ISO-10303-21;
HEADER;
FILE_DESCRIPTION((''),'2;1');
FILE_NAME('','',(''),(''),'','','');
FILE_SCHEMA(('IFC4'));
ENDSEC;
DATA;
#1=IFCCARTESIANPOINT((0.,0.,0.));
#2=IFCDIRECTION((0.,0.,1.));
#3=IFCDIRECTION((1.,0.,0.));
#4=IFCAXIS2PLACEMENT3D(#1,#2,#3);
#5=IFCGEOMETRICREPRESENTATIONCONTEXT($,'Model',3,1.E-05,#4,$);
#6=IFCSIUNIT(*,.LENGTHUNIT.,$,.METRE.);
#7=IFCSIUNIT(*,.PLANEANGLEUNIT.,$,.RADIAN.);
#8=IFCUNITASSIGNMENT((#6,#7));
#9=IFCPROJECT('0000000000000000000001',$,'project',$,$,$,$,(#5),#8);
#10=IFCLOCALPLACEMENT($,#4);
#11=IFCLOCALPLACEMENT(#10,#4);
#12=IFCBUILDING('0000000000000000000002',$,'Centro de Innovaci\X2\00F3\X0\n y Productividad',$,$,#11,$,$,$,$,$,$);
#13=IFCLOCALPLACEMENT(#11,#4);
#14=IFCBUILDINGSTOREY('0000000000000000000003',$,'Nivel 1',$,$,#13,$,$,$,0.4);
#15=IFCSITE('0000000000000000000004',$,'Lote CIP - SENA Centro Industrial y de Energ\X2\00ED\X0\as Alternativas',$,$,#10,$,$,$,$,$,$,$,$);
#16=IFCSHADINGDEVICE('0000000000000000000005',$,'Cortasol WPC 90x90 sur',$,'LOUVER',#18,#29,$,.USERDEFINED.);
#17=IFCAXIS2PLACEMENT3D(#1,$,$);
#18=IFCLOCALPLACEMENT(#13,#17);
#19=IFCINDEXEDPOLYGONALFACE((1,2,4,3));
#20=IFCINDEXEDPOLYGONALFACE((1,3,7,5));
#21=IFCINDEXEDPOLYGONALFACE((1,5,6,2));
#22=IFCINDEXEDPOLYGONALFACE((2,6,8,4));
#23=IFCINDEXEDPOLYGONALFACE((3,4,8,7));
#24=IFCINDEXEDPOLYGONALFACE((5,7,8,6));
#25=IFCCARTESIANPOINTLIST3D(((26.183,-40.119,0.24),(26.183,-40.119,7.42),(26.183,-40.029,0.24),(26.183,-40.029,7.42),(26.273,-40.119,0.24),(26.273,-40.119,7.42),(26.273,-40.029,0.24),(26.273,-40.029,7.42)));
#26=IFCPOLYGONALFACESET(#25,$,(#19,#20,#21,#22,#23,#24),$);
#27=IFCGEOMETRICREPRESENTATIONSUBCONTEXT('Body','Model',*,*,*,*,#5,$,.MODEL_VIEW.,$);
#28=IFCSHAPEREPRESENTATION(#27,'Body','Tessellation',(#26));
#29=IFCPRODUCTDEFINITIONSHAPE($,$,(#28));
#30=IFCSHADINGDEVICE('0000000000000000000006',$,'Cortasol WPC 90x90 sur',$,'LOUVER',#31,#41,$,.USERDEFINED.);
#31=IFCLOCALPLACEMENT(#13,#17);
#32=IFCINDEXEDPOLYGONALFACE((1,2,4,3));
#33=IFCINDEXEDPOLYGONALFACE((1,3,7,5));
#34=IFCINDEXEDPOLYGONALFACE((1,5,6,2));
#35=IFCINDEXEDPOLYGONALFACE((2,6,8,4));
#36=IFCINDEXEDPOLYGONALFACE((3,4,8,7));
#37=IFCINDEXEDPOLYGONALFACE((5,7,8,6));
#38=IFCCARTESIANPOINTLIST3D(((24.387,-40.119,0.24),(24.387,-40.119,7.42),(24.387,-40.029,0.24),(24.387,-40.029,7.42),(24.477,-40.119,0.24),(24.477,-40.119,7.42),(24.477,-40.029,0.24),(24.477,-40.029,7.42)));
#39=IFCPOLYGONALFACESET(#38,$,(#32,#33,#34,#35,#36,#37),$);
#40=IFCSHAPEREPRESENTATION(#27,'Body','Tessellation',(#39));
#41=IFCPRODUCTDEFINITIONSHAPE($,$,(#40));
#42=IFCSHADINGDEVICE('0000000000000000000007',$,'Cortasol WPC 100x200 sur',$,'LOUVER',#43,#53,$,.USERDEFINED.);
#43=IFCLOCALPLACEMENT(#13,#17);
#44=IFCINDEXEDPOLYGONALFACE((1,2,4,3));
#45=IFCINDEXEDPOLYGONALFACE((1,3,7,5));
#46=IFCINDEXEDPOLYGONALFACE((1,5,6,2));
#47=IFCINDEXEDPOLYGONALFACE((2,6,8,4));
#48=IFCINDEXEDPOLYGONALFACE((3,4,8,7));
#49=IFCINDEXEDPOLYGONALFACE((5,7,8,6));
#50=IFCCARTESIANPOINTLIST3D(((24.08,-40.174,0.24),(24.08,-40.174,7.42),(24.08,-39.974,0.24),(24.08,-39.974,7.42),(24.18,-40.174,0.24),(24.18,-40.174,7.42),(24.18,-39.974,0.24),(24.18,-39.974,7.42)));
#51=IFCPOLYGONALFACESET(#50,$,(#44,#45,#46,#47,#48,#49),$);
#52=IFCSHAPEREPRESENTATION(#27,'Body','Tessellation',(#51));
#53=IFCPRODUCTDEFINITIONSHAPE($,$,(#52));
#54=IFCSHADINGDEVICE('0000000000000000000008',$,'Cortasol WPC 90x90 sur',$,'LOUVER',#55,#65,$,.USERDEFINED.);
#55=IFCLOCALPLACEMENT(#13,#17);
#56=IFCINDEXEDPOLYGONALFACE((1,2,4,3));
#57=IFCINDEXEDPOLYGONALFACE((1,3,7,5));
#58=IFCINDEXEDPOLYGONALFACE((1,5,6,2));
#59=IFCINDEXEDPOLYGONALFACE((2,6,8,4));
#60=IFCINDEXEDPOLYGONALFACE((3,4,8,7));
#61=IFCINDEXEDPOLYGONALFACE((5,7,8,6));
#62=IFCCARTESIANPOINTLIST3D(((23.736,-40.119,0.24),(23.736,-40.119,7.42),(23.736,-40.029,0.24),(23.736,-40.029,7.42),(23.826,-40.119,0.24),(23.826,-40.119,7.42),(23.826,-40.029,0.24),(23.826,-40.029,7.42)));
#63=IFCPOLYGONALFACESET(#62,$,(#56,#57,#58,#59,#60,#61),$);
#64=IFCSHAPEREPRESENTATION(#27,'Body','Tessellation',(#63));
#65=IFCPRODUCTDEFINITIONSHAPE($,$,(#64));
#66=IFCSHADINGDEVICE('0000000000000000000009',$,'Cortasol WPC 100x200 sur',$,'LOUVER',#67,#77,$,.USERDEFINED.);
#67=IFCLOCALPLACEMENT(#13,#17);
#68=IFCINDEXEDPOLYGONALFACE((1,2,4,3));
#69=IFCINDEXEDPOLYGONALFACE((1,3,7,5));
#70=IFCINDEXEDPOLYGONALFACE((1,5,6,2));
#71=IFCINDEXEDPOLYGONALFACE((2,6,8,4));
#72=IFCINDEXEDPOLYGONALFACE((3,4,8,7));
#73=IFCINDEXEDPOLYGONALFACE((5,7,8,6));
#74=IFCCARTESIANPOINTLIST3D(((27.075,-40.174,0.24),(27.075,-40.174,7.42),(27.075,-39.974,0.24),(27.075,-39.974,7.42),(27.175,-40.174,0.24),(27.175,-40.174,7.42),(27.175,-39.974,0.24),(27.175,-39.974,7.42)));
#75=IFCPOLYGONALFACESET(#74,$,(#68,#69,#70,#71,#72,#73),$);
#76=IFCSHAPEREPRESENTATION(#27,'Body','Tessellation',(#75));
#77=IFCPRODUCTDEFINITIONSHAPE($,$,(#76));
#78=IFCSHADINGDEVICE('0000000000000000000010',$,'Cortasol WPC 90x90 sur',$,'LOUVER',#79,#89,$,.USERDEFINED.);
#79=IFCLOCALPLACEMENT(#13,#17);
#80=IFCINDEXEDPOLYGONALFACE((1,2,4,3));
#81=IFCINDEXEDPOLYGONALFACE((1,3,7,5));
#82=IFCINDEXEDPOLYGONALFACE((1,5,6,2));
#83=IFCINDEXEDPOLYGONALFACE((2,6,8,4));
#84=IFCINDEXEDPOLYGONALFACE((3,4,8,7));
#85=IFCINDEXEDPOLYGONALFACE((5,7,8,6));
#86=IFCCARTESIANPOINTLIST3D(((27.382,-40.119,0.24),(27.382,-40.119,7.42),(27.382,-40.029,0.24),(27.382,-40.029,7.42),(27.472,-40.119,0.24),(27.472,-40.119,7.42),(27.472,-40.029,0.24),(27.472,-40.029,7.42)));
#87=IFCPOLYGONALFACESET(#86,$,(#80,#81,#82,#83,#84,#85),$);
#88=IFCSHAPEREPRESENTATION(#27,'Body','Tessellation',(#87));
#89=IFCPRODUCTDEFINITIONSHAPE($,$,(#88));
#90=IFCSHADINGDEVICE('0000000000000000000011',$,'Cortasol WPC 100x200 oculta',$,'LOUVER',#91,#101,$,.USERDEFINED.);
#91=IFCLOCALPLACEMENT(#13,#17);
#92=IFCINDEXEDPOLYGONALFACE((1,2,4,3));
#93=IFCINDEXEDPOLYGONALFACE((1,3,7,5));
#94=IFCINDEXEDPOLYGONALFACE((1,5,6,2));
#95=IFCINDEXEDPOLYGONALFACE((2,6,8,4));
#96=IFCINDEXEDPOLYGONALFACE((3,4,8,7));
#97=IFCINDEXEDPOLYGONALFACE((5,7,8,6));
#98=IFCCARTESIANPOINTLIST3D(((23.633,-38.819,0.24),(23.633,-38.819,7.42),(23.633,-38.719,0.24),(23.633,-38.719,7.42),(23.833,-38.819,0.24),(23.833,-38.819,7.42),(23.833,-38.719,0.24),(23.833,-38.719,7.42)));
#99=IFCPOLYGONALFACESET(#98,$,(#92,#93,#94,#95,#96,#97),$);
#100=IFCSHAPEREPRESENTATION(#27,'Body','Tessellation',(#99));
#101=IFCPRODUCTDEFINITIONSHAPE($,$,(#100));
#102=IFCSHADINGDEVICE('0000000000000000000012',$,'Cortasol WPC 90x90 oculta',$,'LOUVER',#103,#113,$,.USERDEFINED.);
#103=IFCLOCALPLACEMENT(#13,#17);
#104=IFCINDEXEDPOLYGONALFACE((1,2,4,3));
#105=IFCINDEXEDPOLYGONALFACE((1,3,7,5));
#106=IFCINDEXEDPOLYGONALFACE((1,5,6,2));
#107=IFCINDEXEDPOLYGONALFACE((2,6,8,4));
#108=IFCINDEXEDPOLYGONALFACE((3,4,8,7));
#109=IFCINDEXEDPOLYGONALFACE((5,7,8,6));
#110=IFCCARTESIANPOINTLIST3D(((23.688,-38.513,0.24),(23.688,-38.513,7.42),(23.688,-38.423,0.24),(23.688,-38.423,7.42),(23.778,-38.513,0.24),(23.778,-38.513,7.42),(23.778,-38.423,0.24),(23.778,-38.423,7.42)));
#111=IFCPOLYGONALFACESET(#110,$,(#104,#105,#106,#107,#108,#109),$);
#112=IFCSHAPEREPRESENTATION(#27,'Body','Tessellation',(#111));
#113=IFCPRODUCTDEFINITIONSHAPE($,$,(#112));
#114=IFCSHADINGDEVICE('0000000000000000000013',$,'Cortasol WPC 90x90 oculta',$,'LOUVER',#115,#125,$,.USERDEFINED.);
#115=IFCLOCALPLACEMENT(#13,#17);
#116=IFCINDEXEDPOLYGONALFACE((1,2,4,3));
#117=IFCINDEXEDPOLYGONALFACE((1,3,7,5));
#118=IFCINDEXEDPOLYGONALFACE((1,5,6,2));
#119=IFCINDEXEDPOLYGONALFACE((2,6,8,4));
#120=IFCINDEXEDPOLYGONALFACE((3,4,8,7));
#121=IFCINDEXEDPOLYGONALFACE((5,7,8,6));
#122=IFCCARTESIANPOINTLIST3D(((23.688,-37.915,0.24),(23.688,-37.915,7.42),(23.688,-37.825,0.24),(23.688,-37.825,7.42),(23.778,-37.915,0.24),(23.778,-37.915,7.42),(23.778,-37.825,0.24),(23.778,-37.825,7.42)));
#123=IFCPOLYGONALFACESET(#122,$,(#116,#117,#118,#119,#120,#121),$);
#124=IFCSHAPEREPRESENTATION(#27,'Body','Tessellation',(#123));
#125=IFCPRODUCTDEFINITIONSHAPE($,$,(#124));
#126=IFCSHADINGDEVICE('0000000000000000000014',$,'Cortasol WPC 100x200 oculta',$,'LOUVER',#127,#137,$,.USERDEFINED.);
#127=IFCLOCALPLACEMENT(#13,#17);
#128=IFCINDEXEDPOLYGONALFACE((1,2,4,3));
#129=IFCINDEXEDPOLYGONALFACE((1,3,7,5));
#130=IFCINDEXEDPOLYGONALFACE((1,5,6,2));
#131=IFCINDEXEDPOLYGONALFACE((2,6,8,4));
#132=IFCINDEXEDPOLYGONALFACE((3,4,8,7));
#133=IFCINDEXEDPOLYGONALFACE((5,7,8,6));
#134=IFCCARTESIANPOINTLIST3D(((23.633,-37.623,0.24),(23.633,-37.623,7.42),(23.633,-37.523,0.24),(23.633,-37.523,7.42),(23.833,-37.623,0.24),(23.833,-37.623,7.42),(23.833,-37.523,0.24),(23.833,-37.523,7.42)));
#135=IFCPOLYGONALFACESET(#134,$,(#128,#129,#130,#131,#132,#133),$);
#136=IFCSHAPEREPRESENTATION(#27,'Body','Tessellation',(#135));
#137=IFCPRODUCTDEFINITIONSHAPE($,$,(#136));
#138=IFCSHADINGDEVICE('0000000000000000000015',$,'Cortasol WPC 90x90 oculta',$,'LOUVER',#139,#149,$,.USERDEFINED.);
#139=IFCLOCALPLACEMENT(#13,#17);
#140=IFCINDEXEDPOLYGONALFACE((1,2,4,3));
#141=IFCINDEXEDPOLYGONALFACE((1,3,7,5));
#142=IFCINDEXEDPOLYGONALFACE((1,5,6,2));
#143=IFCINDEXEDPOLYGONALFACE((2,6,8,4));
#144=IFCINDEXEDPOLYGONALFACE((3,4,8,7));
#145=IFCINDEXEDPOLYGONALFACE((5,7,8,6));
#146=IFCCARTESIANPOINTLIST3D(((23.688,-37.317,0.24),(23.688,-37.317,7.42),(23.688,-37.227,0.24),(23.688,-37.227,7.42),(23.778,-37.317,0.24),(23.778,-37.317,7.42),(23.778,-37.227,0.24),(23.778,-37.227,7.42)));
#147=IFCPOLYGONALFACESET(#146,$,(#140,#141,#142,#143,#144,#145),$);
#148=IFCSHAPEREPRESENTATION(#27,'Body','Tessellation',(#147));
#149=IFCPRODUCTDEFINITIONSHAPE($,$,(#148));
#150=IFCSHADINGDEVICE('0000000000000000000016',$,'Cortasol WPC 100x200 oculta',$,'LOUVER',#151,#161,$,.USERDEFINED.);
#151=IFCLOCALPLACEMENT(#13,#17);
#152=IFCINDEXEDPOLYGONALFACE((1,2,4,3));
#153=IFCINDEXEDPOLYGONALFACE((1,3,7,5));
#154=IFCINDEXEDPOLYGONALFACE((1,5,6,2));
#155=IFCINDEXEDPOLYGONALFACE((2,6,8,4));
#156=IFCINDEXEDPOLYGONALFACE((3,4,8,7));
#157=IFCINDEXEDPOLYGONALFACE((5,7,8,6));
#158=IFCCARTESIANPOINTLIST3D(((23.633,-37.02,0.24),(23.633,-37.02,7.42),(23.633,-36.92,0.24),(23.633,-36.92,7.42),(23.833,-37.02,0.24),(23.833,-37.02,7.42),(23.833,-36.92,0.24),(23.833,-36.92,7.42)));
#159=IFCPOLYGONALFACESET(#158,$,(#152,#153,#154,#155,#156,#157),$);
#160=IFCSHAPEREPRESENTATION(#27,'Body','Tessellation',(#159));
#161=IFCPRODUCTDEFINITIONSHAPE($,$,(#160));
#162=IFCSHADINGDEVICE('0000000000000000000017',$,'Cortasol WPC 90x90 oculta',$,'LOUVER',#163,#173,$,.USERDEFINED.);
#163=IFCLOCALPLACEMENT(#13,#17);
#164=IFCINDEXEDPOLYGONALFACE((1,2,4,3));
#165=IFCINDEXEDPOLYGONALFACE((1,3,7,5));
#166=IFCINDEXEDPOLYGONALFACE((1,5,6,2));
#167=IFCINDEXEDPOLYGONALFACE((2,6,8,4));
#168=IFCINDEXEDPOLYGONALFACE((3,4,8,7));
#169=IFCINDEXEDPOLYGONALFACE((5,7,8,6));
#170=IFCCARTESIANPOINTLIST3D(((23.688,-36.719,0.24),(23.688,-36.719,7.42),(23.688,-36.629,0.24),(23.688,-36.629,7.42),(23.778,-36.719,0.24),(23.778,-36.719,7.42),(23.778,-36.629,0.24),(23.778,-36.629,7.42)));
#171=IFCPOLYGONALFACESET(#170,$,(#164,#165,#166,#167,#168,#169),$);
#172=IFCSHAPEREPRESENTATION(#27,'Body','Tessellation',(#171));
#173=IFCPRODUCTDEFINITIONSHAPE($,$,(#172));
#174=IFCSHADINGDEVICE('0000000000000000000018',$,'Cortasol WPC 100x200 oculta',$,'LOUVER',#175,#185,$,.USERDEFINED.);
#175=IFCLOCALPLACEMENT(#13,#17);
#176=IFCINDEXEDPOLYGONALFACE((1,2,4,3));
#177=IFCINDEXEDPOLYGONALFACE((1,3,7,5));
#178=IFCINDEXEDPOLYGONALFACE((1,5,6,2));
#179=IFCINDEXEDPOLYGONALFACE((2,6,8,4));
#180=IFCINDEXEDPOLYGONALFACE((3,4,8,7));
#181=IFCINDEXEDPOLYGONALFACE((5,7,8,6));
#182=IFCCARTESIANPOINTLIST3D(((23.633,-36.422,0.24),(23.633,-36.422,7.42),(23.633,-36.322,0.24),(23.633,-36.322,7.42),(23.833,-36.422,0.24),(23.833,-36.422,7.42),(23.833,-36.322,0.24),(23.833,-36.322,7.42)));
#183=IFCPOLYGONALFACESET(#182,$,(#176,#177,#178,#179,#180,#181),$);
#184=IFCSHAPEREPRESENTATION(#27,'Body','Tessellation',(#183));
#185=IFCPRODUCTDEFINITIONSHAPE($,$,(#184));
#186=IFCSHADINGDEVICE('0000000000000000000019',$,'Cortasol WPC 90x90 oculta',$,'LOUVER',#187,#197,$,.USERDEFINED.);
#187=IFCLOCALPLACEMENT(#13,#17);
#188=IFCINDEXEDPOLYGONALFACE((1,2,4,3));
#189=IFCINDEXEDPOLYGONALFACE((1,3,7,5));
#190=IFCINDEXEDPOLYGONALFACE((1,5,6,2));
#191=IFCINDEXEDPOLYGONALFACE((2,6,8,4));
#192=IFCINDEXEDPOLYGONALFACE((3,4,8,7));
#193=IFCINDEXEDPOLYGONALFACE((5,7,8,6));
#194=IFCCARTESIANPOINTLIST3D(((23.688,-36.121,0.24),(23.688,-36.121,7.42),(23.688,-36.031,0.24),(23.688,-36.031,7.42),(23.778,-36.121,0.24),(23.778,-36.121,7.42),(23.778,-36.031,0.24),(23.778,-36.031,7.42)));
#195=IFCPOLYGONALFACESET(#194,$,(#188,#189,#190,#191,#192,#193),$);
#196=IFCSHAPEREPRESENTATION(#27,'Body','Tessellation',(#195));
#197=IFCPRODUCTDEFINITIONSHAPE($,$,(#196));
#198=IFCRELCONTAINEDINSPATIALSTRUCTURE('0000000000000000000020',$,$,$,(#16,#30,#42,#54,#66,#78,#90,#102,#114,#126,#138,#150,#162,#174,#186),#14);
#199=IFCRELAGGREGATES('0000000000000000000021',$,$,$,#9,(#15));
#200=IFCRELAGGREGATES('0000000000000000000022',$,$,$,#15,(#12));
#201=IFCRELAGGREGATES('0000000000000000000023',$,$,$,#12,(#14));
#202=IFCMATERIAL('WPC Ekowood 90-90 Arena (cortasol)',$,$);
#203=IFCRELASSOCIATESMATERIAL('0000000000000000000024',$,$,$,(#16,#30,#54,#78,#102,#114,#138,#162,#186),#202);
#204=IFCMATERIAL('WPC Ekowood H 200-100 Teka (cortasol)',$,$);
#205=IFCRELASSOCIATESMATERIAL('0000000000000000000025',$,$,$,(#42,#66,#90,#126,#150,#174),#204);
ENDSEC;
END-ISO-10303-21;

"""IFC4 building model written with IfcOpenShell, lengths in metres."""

from ifc_helpers import new_model, si_unit, frame, origin_with_axes, place, context, subcontext, project, spatial, polyline, outline, extrude, material, element, save


model = new_model("IFC4")

# Units and contexts
model_context = context("Model", 3, precision=1e-05, world=origin_with_axes())
body_context = subcontext(model_context, "Body", "Model", "MODEL_VIEW")
ifc_project = project(units=[si_unit("LENGTHUNIT", "METRE"), si_unit("PLANEANGLEUNIT", "RADIAN")], contexts=[model_context])

# Site, building, storey
site_placement = place(None, origin_with_axes())
site = spatial("IfcSite", under=ifc_project, at=site_placement, Name="Lote CIP - SENA Centro Industrial y de Energías Alternativas")
building_placement = place(site_placement, origin_with_axes())
building = spatial("IfcBuilding", under=site, at=building_placement, Name="Centro de Innovación y Productividad")
storey_placement = place(building_placement, origin_with_axes())
storey = spatial("IfcBuildingStorey", under=building, at=storey_placement, Name="Nivel 1", Elevation=0.4)

# Shading devices
ifc_material_1 = material(Name="WPC Ekowood 90-90 Arena (cortasol)")
shading_device_1_placement = place(storey_placement, origin_with_axes())
element("IfcShadingDevice", 1, at=shading_device_1_placement, inside=storey, material=ifc_material_1, Name="Cortasol WPC 90x90 sur", ObjectType="LOUVER", PredefinedType="USERDEFINED", context=body_context, shape_type="SweptSolid", body=[
    extrude(outline(polyline([(26.183, -40.119), (26.183, -40.029), (26.273, -40.029), (26.273, -40.119), (26.183, -40.119)])), frame((0.0, 0.0, 0.24)), (0.0, 0.0, 1.0), 7.18),
])
shading_device_2_placement = place(storey_placement, origin_with_axes())
element("IfcShadingDevice", 2, at=shading_device_2_placement, inside=storey, material=ifc_material_1, Name="Cortasol WPC 90x90 sur", ObjectType="LOUVER", PredefinedType="USERDEFINED", context=body_context, shape_type="SweptSolid", body=[
    extrude(outline(polyline([(24.387, -40.119), (24.387, -40.029), (24.477, -40.029), (24.477, -40.119), (24.387, -40.119)])), frame((0.0, 0.0, 0.24)), (0.0, 0.0, 1.0), 7.18),
])
ifc_material_2 = material(Name="WPC Ekowood H 200-100 Teka (cortasol)")
shading_device_3_placement = place(storey_placement, origin_with_axes())
element("IfcShadingDevice", 3, at=shading_device_3_placement, inside=storey, material=ifc_material_2, Name="Cortasol WPC 100x200 sur", ObjectType="LOUVER", PredefinedType="USERDEFINED", context=body_context, shape_type="SweptSolid", body=[
    extrude(outline(polyline([(24.08, -40.174), (24.08, -39.974), (24.18, -39.974), (24.18, -40.174), (24.08, -40.174)])), frame((0.0, 0.0, 0.24)), (0.0, 0.0, 1.0), 7.18),
])
shading_device_4_placement = place(storey_placement, origin_with_axes())
element("IfcShadingDevice", 4, at=shading_device_4_placement, inside=storey, material=ifc_material_1, Name="Cortasol WPC 90x90 sur", ObjectType="LOUVER", PredefinedType="USERDEFINED", context=body_context, shape_type="SweptSolid", body=[
    extrude(outline(polyline([(23.736, -40.119), (23.736, -40.029), (23.826, -40.029), (23.826, -40.119), (23.736, -40.119)])), frame((0.0, 0.0, 0.24)), (0.0, 0.0, 1.0), 7.18),
])
shading_device_5_placement = place(storey_placement, origin_with_axes())
element("IfcShadingDevice", 5, at=shading_device_5_placement, inside=storey, material=ifc_material_2, Name="Cortasol WPC 100x200 sur", ObjectType="LOUVER", PredefinedType="USERDEFINED", context=body_context, shape_type="SweptSolid", body=[
    extrude(outline(polyline([(27.075, -40.174), (27.075, -39.974), (27.175, -39.974), (27.175, -40.174), (27.075, -40.174)])), frame((0.0, 0.0, 0.24)), (0.0, 0.0, 1.0), 7.18),
])
shading_device_6_placement = place(storey_placement, origin_with_axes())
element("IfcShadingDevice", 6, at=shading_device_6_placement, inside=storey, material=ifc_material_1, Name="Cortasol WPC 90x90 sur", ObjectType="LOUVER", PredefinedType="USERDEFINED", context=body_context, shape_type="SweptSolid", body=[
    extrude(outline(polyline([(27.382, -40.119), (27.382, -40.029), (27.472, -40.029), (27.472, -40.119), (27.382, -40.119)])), frame((0.0, 0.0, 0.24)), (0.0, 0.0, 1.0), 7.18),
])
shading_device_7_placement = place(storey_placement, origin_with_axes())
element("IfcShadingDevice", 7, at=shading_device_7_placement, inside=storey, material=ifc_material_2, Name="Cortasol WPC 100x200 oculta", ObjectType="LOUVER", PredefinedType="USERDEFINED", context=body_context, shape_type="SweptSolid", body=[
    extrude(outline(polyline([(23.833, -38.819), (23.633, -38.819), (23.633, -38.719), (23.833, -38.719), (23.833, -38.819)])), frame((0.0, 0.0, 0.24)), (0.0, 0.0, 1.0), 7.18),
])
shading_device_8_placement = place(storey_placement, origin_with_axes())
element("IfcShadingDevice", 8, at=shading_device_8_placement, inside=storey, material=ifc_material_1, Name="Cortasol WPC 90x90 oculta", ObjectType="LOUVER", PredefinedType="USERDEFINED", context=body_context, shape_type="SweptSolid", body=[
    extrude(outline(polyline([(23.778, -38.513), (23.688, -38.513), (23.688, -38.423), (23.778, -38.423), (23.778, -38.513)])), frame((0.0, 0.0, 0.24)), (0.0, 0.0, 1.0), 7.18),
])
shading_device_9_placement = place(storey_placement, origin_with_axes())
element("IfcShadingDevice", 9, at=shading_device_9_placement, inside=storey, material=ifc_material_1, Name="Cortasol WPC 90x90 oculta", ObjectType="LOUVER", PredefinedType="USERDEFINED", context=body_context, shape_type="SweptSolid", body=[
    extrude(outline(polyline([(23.778, -37.915), (23.688, -37.915), (23.688, -37.825), (23.778, -37.825), (23.778, -37.915)])), frame((0.0, 0.0, 0.24)), (0.0, 0.0, 1.0), 7.18),
])
shading_device_10_placement = place(storey_placement, origin_with_axes())
element("IfcShadingDevice", 10, at=shading_device_10_placement, inside=storey, material=ifc_material_2, Name="Cortasol WPC 100x200 oculta", ObjectType="LOUVER", PredefinedType="USERDEFINED", context=body_context, shape_type="SweptSolid", body=[
    extrude(outline(polyline([(23.833, -37.623), (23.633, -37.623), (23.633, -37.523), (23.833, -37.523), (23.833, -37.623)])), frame((0.0, 0.0, 0.24)), (0.0, 0.0, 1.0), 7.18),
])
shading_device_11_placement = place(storey_placement, origin_with_axes())
element("IfcShadingDevice", 11, at=shading_device_11_placement, inside=storey, material=ifc_material_1, Name="Cortasol WPC 90x90 oculta", ObjectType="LOUVER", PredefinedType="USERDEFINED", context=body_context, shape_type="SweptSolid", body=[
    extrude(outline(polyline([(23.778, -37.317), (23.688, -37.317), (23.688, -37.227), (23.778, -37.227), (23.778, -37.317)])), frame((0.0, 0.0, 0.24)), (0.0, 0.0, 1.0), 7.18),
])
shading_device_12_placement = place(storey_placement, origin_with_axes())
element("IfcShadingDevice", 12, at=shading_device_12_placement, inside=storey, material=ifc_material_2, Name="Cortasol WPC 100x200 oculta", ObjectType="LOUVER", PredefinedType="USERDEFINED", context=body_context, shape_type="SweptSolid", body=[
    extrude(outline(polyline([(23.833, -37.02), (23.633, -37.02), (23.633, -36.92), (23.833, -36.92), (23.833, -37.02)])), frame((0.0, 0.0, 0.24)), (0.0, 0.0, 1.0), 7.18),
])
shading_device_13_placement = place(storey_placement, origin_with_axes())
element("IfcShadingDevice", 13, at=shading_device_13_placement, inside=storey, material=ifc_material_1, Name="Cortasol WPC 90x90 oculta", ObjectType="LOUVER", PredefinedType="USERDEFINED", context=body_context, shape_type="SweptSolid", body=[
    extrude(outline(polyline([(23.778, -36.719), (23.688, -36.719), (23.688, -36.629), (23.778, -36.629), (23.778, -36.719)])), frame((0.0, 0.0, 0.24)), (0.0, 0.0, 1.0), 7.18),
])
shading_device_14_placement = place(storey_placement, origin_with_axes())
element("IfcShadingDevice", 14, at=shading_device_14_placement, inside=storey, material=ifc_material_2, Name="Cortasol WPC 100x200 oculta", ObjectType="LOUVER", PredefinedType="USERDEFINED", context=body_context, shape_type="SweptSolid", body=[
    extrude(outline(polyline([(23.833, -36.422), (23.633, -36.422), (23.633, -36.322), (23.833, -36.322), (23.833, -36.422)])), frame((0.0, 0.0, 0.24)), (0.0, 0.0, 1.0), 7.18),
])
shading_device_15_placement = place(storey_placement, origin_with_axes())
element("IfcShadingDevice", 15, at=shading_device_15_placement, inside=storey, material=ifc_material_1, Name="Cortasol WPC 90x90 oculta", ObjectType="LOUVER", PredefinedType="USERDEFINED", context=body_context, shape_type="SweptSolid", body=[
    extrude(outline(polyline([(23.778, -36.121), (23.688, -36.121), (23.688, -36.031), (23.778, -36.031), (23.778, -36.121)])), frame((0.0, 0.0, 0.24)), (0.0, 0.0, 1.0), 7.18),
])

save(model, "model.ifc")
